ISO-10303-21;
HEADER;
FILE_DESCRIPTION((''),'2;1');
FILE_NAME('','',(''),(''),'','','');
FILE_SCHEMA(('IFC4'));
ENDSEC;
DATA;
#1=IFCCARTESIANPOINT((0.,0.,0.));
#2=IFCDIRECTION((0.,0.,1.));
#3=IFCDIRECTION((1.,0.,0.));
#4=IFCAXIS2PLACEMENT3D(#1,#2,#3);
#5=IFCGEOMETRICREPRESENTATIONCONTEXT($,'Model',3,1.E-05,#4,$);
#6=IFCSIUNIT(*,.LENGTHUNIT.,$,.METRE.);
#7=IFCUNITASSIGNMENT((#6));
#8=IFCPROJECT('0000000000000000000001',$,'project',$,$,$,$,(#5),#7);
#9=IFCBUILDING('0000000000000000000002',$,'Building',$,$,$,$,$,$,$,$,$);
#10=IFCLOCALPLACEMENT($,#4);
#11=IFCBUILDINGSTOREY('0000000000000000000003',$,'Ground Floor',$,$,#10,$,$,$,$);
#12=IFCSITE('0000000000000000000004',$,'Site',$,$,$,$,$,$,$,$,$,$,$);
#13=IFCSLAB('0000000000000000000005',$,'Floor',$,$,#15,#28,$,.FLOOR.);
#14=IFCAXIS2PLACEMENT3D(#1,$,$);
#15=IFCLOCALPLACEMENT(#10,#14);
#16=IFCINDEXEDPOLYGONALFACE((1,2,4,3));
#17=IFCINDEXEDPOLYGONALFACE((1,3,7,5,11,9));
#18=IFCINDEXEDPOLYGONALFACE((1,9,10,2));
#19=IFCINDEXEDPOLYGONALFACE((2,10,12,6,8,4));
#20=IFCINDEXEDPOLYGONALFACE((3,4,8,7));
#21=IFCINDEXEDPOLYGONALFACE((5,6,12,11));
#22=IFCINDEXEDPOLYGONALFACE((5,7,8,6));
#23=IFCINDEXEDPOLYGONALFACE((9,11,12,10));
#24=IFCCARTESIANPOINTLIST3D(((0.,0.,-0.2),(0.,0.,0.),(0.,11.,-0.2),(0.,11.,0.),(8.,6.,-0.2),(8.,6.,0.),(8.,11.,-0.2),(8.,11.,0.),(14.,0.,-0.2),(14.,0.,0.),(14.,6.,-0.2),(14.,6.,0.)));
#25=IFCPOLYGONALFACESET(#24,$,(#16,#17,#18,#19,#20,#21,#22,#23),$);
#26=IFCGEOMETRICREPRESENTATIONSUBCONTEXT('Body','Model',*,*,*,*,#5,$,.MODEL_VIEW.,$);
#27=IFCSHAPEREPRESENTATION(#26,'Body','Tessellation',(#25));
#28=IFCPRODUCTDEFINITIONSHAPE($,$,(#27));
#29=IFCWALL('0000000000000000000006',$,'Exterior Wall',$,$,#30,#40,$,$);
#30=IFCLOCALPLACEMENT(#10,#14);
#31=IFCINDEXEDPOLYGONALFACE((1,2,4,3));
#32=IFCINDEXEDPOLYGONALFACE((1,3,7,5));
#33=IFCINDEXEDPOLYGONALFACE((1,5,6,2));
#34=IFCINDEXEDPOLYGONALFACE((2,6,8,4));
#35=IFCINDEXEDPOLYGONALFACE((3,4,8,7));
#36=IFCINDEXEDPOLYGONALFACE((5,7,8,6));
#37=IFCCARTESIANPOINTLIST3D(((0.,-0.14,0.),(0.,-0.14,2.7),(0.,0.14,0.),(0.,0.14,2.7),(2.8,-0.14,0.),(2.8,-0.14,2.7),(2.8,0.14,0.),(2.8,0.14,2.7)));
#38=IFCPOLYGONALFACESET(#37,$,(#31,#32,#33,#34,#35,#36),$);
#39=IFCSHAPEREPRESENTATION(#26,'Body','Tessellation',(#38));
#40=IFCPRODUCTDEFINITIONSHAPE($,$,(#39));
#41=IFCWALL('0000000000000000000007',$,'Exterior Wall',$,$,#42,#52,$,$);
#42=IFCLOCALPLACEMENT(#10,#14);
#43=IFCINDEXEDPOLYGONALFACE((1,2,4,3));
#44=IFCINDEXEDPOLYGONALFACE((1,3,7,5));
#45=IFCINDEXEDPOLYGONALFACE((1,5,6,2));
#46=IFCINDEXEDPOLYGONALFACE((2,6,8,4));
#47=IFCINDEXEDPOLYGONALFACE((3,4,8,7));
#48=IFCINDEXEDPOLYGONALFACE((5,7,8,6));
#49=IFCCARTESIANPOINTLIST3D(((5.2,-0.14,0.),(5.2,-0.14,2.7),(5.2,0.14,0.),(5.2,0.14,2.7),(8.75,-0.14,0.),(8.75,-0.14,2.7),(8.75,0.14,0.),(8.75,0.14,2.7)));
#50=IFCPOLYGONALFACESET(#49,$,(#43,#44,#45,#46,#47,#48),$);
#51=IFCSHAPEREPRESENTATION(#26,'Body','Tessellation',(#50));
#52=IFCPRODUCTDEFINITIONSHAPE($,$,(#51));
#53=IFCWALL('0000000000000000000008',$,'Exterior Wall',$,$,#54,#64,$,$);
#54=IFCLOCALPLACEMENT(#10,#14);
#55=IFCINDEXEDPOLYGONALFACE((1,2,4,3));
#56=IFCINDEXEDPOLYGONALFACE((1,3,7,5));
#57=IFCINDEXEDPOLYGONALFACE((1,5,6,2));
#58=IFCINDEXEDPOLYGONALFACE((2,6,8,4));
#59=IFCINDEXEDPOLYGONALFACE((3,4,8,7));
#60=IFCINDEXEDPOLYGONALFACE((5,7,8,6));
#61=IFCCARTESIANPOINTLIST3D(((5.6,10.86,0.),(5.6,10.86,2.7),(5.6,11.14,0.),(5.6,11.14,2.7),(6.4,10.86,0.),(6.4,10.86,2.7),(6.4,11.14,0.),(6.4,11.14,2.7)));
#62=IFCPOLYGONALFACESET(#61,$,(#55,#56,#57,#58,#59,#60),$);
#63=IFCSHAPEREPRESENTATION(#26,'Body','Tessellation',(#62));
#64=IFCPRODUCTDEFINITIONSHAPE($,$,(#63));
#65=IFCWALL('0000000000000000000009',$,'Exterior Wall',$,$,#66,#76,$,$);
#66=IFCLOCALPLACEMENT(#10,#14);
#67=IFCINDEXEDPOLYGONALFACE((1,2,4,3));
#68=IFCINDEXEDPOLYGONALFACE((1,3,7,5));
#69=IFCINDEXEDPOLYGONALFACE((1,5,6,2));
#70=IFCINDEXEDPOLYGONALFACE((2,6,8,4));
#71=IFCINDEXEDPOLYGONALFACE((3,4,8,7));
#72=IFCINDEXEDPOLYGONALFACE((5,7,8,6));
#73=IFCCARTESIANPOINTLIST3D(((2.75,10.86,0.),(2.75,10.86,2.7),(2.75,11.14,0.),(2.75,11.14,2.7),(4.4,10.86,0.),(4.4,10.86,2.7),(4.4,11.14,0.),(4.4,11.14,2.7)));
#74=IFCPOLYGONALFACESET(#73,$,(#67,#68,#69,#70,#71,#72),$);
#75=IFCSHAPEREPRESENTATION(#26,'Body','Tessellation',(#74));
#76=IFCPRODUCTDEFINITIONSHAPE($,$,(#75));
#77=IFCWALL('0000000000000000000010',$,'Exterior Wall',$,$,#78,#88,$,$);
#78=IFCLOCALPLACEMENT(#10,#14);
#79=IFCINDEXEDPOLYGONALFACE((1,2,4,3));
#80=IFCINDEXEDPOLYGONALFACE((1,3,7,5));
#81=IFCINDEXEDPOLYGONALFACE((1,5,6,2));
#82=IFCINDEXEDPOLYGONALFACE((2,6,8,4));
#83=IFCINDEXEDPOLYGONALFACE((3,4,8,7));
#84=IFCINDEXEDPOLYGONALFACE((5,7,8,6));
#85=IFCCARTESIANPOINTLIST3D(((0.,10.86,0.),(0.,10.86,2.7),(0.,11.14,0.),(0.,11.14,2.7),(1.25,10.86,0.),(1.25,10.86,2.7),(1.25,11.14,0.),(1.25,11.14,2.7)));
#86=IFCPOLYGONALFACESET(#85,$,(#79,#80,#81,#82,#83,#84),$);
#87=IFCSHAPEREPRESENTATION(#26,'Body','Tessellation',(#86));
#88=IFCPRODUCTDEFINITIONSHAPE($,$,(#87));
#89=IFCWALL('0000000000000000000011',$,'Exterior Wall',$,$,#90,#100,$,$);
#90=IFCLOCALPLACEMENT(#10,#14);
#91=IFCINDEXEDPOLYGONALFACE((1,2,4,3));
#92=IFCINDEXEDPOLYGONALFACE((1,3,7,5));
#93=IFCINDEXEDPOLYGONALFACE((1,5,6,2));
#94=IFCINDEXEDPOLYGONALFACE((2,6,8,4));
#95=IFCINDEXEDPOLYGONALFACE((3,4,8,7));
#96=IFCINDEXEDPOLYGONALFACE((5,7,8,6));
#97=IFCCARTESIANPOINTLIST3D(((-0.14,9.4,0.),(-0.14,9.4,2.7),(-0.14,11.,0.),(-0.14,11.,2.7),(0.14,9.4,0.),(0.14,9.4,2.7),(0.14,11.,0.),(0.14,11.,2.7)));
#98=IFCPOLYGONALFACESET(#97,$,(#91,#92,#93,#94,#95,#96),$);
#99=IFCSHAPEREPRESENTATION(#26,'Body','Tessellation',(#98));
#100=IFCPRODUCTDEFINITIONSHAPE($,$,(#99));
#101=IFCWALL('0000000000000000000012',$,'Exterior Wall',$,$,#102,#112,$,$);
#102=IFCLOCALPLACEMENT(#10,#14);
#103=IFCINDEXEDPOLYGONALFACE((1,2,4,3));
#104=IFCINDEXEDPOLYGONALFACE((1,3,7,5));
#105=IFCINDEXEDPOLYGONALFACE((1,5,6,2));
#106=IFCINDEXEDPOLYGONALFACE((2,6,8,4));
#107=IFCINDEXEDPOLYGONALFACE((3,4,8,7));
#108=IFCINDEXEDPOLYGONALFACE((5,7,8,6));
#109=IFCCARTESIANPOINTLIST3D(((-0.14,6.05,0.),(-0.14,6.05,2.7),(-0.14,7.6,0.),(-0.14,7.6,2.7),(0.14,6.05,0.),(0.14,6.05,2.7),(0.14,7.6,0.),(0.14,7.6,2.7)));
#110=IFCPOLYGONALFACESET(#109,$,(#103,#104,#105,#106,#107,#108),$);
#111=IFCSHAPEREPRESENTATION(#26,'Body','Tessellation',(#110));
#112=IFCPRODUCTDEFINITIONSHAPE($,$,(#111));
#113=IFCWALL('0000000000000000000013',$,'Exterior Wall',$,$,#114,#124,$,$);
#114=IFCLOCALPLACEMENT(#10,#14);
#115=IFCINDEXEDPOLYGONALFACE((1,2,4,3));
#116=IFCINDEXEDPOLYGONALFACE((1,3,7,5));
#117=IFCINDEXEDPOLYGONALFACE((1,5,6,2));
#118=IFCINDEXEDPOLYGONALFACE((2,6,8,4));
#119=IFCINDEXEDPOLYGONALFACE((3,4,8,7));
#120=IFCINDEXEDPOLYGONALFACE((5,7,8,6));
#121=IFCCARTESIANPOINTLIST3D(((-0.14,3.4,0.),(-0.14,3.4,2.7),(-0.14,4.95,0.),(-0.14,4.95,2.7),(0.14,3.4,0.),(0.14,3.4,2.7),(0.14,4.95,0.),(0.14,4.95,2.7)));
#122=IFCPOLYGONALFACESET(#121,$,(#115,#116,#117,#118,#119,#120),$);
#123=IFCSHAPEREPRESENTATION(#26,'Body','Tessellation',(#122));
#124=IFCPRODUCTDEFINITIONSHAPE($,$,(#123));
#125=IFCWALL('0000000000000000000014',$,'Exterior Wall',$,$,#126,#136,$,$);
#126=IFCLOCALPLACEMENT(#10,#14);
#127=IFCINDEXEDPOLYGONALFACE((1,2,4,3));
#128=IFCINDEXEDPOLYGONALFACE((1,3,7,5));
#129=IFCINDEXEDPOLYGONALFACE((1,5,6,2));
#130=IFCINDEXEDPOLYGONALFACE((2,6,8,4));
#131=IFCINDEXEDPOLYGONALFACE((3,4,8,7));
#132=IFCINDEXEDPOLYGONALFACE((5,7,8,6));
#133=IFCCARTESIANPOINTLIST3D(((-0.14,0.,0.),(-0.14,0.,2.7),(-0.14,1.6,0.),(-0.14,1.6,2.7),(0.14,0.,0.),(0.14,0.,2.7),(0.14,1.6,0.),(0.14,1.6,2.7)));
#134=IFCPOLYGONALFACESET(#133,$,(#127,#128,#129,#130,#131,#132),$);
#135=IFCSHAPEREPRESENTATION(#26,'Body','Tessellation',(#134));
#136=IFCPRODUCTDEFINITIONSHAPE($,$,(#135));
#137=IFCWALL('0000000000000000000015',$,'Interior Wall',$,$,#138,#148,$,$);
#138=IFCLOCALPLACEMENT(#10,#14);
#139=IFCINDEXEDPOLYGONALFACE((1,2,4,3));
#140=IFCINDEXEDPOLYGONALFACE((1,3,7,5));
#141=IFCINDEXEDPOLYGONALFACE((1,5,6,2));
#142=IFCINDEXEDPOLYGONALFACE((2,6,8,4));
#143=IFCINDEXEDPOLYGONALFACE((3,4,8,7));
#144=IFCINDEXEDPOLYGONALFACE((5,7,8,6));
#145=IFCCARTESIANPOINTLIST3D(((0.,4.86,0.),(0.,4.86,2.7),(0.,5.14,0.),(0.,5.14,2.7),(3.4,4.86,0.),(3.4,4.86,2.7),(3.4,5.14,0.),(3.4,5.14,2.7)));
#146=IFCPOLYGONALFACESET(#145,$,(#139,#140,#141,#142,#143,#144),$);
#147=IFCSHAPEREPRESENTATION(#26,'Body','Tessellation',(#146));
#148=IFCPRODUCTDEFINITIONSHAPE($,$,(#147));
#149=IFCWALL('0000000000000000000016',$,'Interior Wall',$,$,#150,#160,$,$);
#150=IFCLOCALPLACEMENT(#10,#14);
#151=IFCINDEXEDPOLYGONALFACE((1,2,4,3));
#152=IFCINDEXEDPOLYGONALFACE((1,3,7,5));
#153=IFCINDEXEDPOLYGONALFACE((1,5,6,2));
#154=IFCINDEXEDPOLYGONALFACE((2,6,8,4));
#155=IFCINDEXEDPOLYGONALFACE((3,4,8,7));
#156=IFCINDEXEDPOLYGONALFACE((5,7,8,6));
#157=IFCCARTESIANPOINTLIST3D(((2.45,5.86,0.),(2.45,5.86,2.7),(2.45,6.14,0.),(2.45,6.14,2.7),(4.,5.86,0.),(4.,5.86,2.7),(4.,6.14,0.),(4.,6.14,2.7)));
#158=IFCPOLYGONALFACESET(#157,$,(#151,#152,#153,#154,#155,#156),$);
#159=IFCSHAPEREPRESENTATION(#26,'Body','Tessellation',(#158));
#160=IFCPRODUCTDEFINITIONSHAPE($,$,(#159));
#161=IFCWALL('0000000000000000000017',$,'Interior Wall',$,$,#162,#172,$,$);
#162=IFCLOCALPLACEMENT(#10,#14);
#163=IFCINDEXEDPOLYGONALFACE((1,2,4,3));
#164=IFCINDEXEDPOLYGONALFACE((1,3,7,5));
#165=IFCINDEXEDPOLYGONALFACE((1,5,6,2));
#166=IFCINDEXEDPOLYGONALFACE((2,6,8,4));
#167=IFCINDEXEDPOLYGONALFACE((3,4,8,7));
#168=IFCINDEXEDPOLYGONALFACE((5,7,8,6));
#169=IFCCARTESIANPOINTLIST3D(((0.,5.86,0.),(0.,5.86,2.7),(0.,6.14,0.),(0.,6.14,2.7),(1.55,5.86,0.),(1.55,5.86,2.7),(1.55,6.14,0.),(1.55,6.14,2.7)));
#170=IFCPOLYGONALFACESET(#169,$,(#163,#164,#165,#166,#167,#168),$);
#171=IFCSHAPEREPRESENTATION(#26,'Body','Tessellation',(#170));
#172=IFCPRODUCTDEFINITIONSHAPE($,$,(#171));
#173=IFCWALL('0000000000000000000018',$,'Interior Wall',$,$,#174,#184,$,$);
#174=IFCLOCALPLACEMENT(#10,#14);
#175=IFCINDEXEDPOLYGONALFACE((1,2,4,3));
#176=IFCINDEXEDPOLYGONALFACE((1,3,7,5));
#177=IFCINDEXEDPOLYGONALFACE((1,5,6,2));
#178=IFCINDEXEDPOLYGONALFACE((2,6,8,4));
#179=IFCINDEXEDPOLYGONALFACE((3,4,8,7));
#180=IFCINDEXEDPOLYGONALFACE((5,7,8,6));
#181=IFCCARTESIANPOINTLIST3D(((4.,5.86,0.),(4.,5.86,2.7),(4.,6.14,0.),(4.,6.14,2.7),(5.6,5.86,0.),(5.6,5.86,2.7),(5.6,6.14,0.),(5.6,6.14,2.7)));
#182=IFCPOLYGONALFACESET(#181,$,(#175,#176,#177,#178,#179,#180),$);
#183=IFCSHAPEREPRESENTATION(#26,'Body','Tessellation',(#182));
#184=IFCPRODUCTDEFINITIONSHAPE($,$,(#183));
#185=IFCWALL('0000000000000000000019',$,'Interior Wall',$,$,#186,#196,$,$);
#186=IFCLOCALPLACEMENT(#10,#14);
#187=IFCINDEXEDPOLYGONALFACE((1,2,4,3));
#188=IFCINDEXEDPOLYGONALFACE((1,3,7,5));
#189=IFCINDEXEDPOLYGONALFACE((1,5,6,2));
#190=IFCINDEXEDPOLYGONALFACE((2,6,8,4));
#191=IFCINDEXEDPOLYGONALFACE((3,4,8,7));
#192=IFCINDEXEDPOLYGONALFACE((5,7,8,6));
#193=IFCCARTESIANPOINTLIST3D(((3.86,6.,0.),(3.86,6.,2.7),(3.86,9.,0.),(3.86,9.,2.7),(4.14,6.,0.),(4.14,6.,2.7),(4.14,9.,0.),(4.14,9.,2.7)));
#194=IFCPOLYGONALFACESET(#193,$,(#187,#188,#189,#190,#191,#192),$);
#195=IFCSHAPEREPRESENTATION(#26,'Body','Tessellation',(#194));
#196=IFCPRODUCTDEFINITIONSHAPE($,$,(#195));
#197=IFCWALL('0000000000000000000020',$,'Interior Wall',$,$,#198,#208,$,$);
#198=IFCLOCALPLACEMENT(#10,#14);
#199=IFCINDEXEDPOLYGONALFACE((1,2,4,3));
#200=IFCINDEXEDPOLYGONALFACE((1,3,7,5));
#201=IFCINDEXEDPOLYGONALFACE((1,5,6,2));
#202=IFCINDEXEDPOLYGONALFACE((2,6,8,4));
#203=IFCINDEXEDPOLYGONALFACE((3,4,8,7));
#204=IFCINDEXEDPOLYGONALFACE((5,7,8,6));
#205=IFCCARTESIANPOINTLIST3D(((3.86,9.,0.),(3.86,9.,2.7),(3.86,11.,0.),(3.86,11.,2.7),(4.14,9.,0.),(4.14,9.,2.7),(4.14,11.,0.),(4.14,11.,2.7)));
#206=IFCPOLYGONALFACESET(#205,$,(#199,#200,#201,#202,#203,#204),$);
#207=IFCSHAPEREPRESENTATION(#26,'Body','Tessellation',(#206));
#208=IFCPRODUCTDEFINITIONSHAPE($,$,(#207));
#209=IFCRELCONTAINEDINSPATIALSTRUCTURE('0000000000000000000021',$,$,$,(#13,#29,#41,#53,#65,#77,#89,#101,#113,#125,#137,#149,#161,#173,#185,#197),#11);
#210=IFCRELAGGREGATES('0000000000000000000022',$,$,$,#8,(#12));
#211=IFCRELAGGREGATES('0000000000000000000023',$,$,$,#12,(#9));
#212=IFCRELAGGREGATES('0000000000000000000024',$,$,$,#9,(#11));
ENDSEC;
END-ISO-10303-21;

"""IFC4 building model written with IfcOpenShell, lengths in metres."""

from ifc_helpers import new_model, si_unit, frame, origin_with_axes, place, context, subcontext, project, spatial, indexed_curve, outline, extrude, element, save


model = new_model("IFC4")

# Units and contexts
model_context = context("Model", 3, precision=1e-05, world=origin_with_axes())
body_context = subcontext(model_context, "Body", "Model", "MODEL_VIEW")
ifc_project = project(units=[si_unit("LENGTHUNIT", "METRE")], contexts=[model_context])

# Site, building, storey
site = spatial("IfcSite", under=ifc_project, Name="Site")
building = spatial("IfcBuilding", under=site, Name="Building")
storey_placement = place(None, origin_with_axes())
storey = spatial("IfcBuildingStorey", under=building, at=storey_placement, Name="Ground Floor")

# Slab
slab_placement = place(storey_placement, frame((0.0, 0.0, -0.2), z_axis=(0.0, 0.0, 1.0), x_axis=(1.0, 0.0, 0.0)))
element("IfcSlab", 1, at=slab_placement, inside=storey, Name="Floor", PredefinedType="FLOOR", context=body_context, shape_type="SweptSolid", body=[
    extrude(outline(indexed_curve([(0.0, 0.0), (14.0, 0.0), (14.0, 6.0), (8.0, 6.0), (8.0, 11.0), (0.0, 11.0)])), None, (0.0, 0.0, 1.0), 0.2),
])

# Walls
wall_1_placement = place(storey_placement, origin_with_axes())
element("IfcWall", 2, at=wall_1_placement, inside=storey, Name="Exterior Wall", context=body_context, shape_type="SweptSolid", body=[
    extrude(outline(indexed_curve([(0.0, 0.0), (0.0, 0.28), (2.8, 0.28), (2.8, 0.0), (0.0, 0.0)], self_intersect=False)), frame((0.0, -0.14, 0.0), z_axis=(0.0, 0.0, 1.0), x_axis=(1.0, 0.0, 0.0)), (0.0, 0.0, 1.0), 2.7),
])
wall_2_placement = place(storey_placement, frame((5.2, 0.0, 0.0), z_axis=(0.0, 0.0, 1.0), x_axis=(1.0, 0.0, 0.0)))
element("IfcWall", 3, at=wall_2_placement, inside=storey, Name="Exterior Wall", context=body_context, shape_type="SweptSolid", body=[
    extrude(outline(indexed_curve([(0.0, 0.0), (0.0, 0.28), (3.55, 0.28), (3.55, 0.0), (0.0, 0.0)], self_intersect=False)), frame((0.0, -0.14, 0.0), z_axis=(0.0, 0.0, 1.0), x_axis=(1.0, 0.0, 0.0)), (0.0, 0.0, 1.0), 2.7),
])
wall_3_placement = place(storey_placement, frame((6.4, 11.0, 0.0), z_axis=(0.0, 0.0, 1.0), x_axis=(-1.0, 0.0, 0.0)))
element("IfcWall", 4, at=wall_3_placement, inside=storey, Name="Exterior Wall", context=body_context, shape_type="SweptSolid", body=[
    extrude(outline(indexed_curve([(0.0, 0.0), (0.0, 0.28), (0.8, 0.28), (0.8, 0.0), (0.0, 0.0)], self_intersect=False)), frame((0.0, -0.14, 0.0), z_axis=(0.0, 0.0, 1.0), x_axis=(1.0, 0.0, 0.0)), (0.0, 0.0, 1.0), 2.7),
])
wall_4_placement = place(storey_placement, frame((4.4, 11.0, 0.0), z_axis=(0.0, 0.0, 1.0), x_axis=(-1.0, 0.0, 0.0)))
element("IfcWall", 5, at=wall_4_placement, inside=storey, Name="Exterior Wall", context=body_context, shape_type="SweptSolid", body=[
    extrude(outline(indexed_curve([(0.0, 0.0), (0.0, 0.28), (1.65, 0.28), (1.65, 0.0), (0.0, 0.0)], self_intersect=False)), frame((0.0, -0.14, 0.0), z_axis=(0.0, 0.0, 1.0), x_axis=(1.0, 0.0, 0.0)), (0.0, 0.0, 1.0), 2.7),
])
wall_5_placement = place(storey_placement, frame((1.25, 11.0, 0.0), z_axis=(0.0, 0.0, 1.0), x_axis=(-1.0, 0.0, 0.0)))
element("IfcWall", 6, at=wall_5_placement, inside=storey, Name="Exterior Wall", context=body_context, shape_type="SweptSolid", body=[
    extrude(outline(indexed_curve([(0.0, 0.0), (0.0, 0.28), (1.25, 0.28), (1.25, 0.0), (0.0, 0.0)], self_intersect=False)), frame((0.0, -0.14, 0.0), z_axis=(0.0, 0.0, 1.0), x_axis=(1.0, 0.0, 0.0)), (0.0, 0.0, 1.0), 2.7),
])
wall_6_placement = place(storey_placement, frame((0.0, 11.0, 0.0), z_axis=(0.0, 0.0, 1.0), x_axis=(0.0, -1.0, 0.0)))
element("IfcWall", 7, at=wall_6_placement, inside=storey, Name="Exterior Wall", context=body_context, shape_type="SweptSolid", body=[
    extrude(outline(indexed_curve([(0.0, 0.0), (0.0, 0.28), (1.6, 0.28), (1.6, 0.0), (0.0, 0.0)], self_intersect=False)), frame((0.0, -0.14, 0.0), z_axis=(0.0, 0.0, 1.0), x_axis=(1.0, 0.0, 0.0)), (0.0, 0.0, 1.0), 2.7),
])
for number, where, z_axis, x_axis, name in (
    (8, (0.0, 7.6, 0.0), (0.0, 0.0, 1.0), (0.0, -1.0, 0.0), "Exterior Wall"),
    (9, (0.0, 4.95, 0.0), (0.0, 0.0, 1.0), (0.0, -1.0, 0.0), "Exterior Wall"),
):
    element("IfcWall", number, at=place(storey_placement, frame(where, z_axis=z_axis, x_axis=x_axis)), inside=storey, Name=name, context=body_context, shape_type="SweptSolid", body=[
        extrude(outline(indexed_curve([(0.0, 0.0), (0.0, 0.28), (1.55, 0.28), (1.55, 0.0), (0.0, 0.0)], self_intersect=False)), frame((0.0, -0.14, 0.0), z_axis=(0.0, 0.0, 1.0), x_axis=(1.0, 0.0, 0.0)), (0.0, 0.0, 1.0), 2.7),
    ])
wall_7_placement = place(storey_placement, frame((0.0, 1.6, 0.0), z_axis=(0.0, 0.0, 1.0), x_axis=(0.0, -1.0, 0.0)))
element("IfcWall", 10, at=wall_7_placement, inside=storey, Name="Exterior Wall", context=body_context, shape_type="SweptSolid", body=[
    extrude(outline(indexed_curve([(0.0, 0.0), (0.0, 0.28), (1.6, 0.28), (1.6, 0.0), (0.0, 0.0)], self_intersect=False)), frame((0.0, -0.14, 0.0), z_axis=(0.0, 0.0, 1.0), x_axis=(1.0, 0.0, 0.0)), (0.0, 0.0, 1.0), 2.7),
])
wall_8_placement = place(storey_placement, frame((3.4, 5.0, 0.0), z_axis=(0.0, 0.0, 1.0), x_axis=(-1.0, 0.0, 0.0)))
element("IfcWall", 11, at=wall_8_placement, inside=storey, Name="Interior Wall", context=body_context, shape_type="SweptSolid", body=[
    extrude(outline(indexed_curve([(0.0, 0.0), (0.0, 0.28), (3.4, 0.28), (3.4, 0.0), (0.0, 0.0)], self_intersect=False)), frame((0.0, -0.14, 0.0), z_axis=(0.0, 0.0, 1.0), x_axis=(1.0, 0.0, 0.0)), (0.0, 0.0, 1.0), 2.7),
])
for number, where, z_axis, x_axis, name in (
    (12, (4.0, 6.0, 0.0), (0.0, 0.0, 1.0), (-1.0, 0.0, 0.0), "Interior Wall"),
    (13, (1.55, 6.0, 0.0), (0.0, 0.0, 1.0), (-1.0, 0.0, 0.0), "Interior Wall"),
):
    element("IfcWall", number, at=place(storey_placement, frame(where, z_axis=z_axis, x_axis=x_axis)), inside=storey, Name=name, context=body_context, shape_type="SweptSolid", body=[
        extrude(outline(indexed_curve([(0.0, 0.0), (0.0, 0.28), (1.55, 0.28), (1.55, 0.0), (0.0, 0.0)], self_intersect=False)), frame((0.0, -0.14, 0.0), z_axis=(0.0, 0.0, 1.0), x_axis=(1.0, 0.0, 0.0)), (0.0, 0.0, 1.0), 2.7),
    ])
wall_9_placement = place(storey_placement, frame((5.6, 6.0, 0.0), z_axis=(0.0, 0.0, 1.0), x_axis=(-1.0, 0.0, 0.0)))
element("IfcWall", 14, at=wall_9_placement, inside=storey, Name="Interior Wall", context=body_context, shape_type="SweptSolid", body=[
    extrude(outline(indexed_curve([(0.0, 0.0), (0.0, 0.28), (1.6, 0.28), (1.6, 0.0), (0.0, 0.0)], self_intersect=False)), frame((0.0, -0.14, 0.0), z_axis=(0.0, 0.0, 1.0), x_axis=(1.0, 0.0, 0.0)), (0.0, 0.0, 1.0), 2.7),
])
wall_10_placement = place(storey_placement, frame((4.0, 6.0, 0.0), z_axis=(0.0, 0.0, 1.0), x_axis=(0.0, 1.0, 0.0)))
element("IfcWall", 15, at=wall_10_placement, inside=storey, Name="Interior Wall", context=body_context, shape_type="SweptSolid", body=[
    extrude(outline(indexed_curve([(0.0, 0.0), (0.0, 0.28), (3.0, 0.28), (3.0, 0.0), (0.0, 0.0)], self_intersect=False)), frame((0.0, -0.14, 0.0), z_axis=(0.0, 0.0, 1.0), x_axis=(1.0, 0.0, 0.0)), (0.0, 0.0, 1.0), 2.7),
])
wall_11_placement = place(storey_placement, frame((4.0, 9.0, 0.0), z_axis=(0.0, 0.0, 1.0), x_axis=(0.0, 1.0, 0.0)))
element("IfcWall", 16, at=wall_11_placement, inside=storey, Name="Interior Wall", context=body_context, shape_type="SweptSolid", body=[
    extrude(outline(indexed_curve([(0.0, 0.0), (0.0, 0.28), (2.0, 0.28), (2.0, 0.0), (0.0, 0.0)], self_intersect=False)), frame((0.0, -0.14, 0.0), z_axis=(0.0, 0.0, 1.0), x_axis=(1.0, 0.0, 0.0)), (0.0, 0.0, 1.0), 2.7),
])

save(model, "model.ifc")
